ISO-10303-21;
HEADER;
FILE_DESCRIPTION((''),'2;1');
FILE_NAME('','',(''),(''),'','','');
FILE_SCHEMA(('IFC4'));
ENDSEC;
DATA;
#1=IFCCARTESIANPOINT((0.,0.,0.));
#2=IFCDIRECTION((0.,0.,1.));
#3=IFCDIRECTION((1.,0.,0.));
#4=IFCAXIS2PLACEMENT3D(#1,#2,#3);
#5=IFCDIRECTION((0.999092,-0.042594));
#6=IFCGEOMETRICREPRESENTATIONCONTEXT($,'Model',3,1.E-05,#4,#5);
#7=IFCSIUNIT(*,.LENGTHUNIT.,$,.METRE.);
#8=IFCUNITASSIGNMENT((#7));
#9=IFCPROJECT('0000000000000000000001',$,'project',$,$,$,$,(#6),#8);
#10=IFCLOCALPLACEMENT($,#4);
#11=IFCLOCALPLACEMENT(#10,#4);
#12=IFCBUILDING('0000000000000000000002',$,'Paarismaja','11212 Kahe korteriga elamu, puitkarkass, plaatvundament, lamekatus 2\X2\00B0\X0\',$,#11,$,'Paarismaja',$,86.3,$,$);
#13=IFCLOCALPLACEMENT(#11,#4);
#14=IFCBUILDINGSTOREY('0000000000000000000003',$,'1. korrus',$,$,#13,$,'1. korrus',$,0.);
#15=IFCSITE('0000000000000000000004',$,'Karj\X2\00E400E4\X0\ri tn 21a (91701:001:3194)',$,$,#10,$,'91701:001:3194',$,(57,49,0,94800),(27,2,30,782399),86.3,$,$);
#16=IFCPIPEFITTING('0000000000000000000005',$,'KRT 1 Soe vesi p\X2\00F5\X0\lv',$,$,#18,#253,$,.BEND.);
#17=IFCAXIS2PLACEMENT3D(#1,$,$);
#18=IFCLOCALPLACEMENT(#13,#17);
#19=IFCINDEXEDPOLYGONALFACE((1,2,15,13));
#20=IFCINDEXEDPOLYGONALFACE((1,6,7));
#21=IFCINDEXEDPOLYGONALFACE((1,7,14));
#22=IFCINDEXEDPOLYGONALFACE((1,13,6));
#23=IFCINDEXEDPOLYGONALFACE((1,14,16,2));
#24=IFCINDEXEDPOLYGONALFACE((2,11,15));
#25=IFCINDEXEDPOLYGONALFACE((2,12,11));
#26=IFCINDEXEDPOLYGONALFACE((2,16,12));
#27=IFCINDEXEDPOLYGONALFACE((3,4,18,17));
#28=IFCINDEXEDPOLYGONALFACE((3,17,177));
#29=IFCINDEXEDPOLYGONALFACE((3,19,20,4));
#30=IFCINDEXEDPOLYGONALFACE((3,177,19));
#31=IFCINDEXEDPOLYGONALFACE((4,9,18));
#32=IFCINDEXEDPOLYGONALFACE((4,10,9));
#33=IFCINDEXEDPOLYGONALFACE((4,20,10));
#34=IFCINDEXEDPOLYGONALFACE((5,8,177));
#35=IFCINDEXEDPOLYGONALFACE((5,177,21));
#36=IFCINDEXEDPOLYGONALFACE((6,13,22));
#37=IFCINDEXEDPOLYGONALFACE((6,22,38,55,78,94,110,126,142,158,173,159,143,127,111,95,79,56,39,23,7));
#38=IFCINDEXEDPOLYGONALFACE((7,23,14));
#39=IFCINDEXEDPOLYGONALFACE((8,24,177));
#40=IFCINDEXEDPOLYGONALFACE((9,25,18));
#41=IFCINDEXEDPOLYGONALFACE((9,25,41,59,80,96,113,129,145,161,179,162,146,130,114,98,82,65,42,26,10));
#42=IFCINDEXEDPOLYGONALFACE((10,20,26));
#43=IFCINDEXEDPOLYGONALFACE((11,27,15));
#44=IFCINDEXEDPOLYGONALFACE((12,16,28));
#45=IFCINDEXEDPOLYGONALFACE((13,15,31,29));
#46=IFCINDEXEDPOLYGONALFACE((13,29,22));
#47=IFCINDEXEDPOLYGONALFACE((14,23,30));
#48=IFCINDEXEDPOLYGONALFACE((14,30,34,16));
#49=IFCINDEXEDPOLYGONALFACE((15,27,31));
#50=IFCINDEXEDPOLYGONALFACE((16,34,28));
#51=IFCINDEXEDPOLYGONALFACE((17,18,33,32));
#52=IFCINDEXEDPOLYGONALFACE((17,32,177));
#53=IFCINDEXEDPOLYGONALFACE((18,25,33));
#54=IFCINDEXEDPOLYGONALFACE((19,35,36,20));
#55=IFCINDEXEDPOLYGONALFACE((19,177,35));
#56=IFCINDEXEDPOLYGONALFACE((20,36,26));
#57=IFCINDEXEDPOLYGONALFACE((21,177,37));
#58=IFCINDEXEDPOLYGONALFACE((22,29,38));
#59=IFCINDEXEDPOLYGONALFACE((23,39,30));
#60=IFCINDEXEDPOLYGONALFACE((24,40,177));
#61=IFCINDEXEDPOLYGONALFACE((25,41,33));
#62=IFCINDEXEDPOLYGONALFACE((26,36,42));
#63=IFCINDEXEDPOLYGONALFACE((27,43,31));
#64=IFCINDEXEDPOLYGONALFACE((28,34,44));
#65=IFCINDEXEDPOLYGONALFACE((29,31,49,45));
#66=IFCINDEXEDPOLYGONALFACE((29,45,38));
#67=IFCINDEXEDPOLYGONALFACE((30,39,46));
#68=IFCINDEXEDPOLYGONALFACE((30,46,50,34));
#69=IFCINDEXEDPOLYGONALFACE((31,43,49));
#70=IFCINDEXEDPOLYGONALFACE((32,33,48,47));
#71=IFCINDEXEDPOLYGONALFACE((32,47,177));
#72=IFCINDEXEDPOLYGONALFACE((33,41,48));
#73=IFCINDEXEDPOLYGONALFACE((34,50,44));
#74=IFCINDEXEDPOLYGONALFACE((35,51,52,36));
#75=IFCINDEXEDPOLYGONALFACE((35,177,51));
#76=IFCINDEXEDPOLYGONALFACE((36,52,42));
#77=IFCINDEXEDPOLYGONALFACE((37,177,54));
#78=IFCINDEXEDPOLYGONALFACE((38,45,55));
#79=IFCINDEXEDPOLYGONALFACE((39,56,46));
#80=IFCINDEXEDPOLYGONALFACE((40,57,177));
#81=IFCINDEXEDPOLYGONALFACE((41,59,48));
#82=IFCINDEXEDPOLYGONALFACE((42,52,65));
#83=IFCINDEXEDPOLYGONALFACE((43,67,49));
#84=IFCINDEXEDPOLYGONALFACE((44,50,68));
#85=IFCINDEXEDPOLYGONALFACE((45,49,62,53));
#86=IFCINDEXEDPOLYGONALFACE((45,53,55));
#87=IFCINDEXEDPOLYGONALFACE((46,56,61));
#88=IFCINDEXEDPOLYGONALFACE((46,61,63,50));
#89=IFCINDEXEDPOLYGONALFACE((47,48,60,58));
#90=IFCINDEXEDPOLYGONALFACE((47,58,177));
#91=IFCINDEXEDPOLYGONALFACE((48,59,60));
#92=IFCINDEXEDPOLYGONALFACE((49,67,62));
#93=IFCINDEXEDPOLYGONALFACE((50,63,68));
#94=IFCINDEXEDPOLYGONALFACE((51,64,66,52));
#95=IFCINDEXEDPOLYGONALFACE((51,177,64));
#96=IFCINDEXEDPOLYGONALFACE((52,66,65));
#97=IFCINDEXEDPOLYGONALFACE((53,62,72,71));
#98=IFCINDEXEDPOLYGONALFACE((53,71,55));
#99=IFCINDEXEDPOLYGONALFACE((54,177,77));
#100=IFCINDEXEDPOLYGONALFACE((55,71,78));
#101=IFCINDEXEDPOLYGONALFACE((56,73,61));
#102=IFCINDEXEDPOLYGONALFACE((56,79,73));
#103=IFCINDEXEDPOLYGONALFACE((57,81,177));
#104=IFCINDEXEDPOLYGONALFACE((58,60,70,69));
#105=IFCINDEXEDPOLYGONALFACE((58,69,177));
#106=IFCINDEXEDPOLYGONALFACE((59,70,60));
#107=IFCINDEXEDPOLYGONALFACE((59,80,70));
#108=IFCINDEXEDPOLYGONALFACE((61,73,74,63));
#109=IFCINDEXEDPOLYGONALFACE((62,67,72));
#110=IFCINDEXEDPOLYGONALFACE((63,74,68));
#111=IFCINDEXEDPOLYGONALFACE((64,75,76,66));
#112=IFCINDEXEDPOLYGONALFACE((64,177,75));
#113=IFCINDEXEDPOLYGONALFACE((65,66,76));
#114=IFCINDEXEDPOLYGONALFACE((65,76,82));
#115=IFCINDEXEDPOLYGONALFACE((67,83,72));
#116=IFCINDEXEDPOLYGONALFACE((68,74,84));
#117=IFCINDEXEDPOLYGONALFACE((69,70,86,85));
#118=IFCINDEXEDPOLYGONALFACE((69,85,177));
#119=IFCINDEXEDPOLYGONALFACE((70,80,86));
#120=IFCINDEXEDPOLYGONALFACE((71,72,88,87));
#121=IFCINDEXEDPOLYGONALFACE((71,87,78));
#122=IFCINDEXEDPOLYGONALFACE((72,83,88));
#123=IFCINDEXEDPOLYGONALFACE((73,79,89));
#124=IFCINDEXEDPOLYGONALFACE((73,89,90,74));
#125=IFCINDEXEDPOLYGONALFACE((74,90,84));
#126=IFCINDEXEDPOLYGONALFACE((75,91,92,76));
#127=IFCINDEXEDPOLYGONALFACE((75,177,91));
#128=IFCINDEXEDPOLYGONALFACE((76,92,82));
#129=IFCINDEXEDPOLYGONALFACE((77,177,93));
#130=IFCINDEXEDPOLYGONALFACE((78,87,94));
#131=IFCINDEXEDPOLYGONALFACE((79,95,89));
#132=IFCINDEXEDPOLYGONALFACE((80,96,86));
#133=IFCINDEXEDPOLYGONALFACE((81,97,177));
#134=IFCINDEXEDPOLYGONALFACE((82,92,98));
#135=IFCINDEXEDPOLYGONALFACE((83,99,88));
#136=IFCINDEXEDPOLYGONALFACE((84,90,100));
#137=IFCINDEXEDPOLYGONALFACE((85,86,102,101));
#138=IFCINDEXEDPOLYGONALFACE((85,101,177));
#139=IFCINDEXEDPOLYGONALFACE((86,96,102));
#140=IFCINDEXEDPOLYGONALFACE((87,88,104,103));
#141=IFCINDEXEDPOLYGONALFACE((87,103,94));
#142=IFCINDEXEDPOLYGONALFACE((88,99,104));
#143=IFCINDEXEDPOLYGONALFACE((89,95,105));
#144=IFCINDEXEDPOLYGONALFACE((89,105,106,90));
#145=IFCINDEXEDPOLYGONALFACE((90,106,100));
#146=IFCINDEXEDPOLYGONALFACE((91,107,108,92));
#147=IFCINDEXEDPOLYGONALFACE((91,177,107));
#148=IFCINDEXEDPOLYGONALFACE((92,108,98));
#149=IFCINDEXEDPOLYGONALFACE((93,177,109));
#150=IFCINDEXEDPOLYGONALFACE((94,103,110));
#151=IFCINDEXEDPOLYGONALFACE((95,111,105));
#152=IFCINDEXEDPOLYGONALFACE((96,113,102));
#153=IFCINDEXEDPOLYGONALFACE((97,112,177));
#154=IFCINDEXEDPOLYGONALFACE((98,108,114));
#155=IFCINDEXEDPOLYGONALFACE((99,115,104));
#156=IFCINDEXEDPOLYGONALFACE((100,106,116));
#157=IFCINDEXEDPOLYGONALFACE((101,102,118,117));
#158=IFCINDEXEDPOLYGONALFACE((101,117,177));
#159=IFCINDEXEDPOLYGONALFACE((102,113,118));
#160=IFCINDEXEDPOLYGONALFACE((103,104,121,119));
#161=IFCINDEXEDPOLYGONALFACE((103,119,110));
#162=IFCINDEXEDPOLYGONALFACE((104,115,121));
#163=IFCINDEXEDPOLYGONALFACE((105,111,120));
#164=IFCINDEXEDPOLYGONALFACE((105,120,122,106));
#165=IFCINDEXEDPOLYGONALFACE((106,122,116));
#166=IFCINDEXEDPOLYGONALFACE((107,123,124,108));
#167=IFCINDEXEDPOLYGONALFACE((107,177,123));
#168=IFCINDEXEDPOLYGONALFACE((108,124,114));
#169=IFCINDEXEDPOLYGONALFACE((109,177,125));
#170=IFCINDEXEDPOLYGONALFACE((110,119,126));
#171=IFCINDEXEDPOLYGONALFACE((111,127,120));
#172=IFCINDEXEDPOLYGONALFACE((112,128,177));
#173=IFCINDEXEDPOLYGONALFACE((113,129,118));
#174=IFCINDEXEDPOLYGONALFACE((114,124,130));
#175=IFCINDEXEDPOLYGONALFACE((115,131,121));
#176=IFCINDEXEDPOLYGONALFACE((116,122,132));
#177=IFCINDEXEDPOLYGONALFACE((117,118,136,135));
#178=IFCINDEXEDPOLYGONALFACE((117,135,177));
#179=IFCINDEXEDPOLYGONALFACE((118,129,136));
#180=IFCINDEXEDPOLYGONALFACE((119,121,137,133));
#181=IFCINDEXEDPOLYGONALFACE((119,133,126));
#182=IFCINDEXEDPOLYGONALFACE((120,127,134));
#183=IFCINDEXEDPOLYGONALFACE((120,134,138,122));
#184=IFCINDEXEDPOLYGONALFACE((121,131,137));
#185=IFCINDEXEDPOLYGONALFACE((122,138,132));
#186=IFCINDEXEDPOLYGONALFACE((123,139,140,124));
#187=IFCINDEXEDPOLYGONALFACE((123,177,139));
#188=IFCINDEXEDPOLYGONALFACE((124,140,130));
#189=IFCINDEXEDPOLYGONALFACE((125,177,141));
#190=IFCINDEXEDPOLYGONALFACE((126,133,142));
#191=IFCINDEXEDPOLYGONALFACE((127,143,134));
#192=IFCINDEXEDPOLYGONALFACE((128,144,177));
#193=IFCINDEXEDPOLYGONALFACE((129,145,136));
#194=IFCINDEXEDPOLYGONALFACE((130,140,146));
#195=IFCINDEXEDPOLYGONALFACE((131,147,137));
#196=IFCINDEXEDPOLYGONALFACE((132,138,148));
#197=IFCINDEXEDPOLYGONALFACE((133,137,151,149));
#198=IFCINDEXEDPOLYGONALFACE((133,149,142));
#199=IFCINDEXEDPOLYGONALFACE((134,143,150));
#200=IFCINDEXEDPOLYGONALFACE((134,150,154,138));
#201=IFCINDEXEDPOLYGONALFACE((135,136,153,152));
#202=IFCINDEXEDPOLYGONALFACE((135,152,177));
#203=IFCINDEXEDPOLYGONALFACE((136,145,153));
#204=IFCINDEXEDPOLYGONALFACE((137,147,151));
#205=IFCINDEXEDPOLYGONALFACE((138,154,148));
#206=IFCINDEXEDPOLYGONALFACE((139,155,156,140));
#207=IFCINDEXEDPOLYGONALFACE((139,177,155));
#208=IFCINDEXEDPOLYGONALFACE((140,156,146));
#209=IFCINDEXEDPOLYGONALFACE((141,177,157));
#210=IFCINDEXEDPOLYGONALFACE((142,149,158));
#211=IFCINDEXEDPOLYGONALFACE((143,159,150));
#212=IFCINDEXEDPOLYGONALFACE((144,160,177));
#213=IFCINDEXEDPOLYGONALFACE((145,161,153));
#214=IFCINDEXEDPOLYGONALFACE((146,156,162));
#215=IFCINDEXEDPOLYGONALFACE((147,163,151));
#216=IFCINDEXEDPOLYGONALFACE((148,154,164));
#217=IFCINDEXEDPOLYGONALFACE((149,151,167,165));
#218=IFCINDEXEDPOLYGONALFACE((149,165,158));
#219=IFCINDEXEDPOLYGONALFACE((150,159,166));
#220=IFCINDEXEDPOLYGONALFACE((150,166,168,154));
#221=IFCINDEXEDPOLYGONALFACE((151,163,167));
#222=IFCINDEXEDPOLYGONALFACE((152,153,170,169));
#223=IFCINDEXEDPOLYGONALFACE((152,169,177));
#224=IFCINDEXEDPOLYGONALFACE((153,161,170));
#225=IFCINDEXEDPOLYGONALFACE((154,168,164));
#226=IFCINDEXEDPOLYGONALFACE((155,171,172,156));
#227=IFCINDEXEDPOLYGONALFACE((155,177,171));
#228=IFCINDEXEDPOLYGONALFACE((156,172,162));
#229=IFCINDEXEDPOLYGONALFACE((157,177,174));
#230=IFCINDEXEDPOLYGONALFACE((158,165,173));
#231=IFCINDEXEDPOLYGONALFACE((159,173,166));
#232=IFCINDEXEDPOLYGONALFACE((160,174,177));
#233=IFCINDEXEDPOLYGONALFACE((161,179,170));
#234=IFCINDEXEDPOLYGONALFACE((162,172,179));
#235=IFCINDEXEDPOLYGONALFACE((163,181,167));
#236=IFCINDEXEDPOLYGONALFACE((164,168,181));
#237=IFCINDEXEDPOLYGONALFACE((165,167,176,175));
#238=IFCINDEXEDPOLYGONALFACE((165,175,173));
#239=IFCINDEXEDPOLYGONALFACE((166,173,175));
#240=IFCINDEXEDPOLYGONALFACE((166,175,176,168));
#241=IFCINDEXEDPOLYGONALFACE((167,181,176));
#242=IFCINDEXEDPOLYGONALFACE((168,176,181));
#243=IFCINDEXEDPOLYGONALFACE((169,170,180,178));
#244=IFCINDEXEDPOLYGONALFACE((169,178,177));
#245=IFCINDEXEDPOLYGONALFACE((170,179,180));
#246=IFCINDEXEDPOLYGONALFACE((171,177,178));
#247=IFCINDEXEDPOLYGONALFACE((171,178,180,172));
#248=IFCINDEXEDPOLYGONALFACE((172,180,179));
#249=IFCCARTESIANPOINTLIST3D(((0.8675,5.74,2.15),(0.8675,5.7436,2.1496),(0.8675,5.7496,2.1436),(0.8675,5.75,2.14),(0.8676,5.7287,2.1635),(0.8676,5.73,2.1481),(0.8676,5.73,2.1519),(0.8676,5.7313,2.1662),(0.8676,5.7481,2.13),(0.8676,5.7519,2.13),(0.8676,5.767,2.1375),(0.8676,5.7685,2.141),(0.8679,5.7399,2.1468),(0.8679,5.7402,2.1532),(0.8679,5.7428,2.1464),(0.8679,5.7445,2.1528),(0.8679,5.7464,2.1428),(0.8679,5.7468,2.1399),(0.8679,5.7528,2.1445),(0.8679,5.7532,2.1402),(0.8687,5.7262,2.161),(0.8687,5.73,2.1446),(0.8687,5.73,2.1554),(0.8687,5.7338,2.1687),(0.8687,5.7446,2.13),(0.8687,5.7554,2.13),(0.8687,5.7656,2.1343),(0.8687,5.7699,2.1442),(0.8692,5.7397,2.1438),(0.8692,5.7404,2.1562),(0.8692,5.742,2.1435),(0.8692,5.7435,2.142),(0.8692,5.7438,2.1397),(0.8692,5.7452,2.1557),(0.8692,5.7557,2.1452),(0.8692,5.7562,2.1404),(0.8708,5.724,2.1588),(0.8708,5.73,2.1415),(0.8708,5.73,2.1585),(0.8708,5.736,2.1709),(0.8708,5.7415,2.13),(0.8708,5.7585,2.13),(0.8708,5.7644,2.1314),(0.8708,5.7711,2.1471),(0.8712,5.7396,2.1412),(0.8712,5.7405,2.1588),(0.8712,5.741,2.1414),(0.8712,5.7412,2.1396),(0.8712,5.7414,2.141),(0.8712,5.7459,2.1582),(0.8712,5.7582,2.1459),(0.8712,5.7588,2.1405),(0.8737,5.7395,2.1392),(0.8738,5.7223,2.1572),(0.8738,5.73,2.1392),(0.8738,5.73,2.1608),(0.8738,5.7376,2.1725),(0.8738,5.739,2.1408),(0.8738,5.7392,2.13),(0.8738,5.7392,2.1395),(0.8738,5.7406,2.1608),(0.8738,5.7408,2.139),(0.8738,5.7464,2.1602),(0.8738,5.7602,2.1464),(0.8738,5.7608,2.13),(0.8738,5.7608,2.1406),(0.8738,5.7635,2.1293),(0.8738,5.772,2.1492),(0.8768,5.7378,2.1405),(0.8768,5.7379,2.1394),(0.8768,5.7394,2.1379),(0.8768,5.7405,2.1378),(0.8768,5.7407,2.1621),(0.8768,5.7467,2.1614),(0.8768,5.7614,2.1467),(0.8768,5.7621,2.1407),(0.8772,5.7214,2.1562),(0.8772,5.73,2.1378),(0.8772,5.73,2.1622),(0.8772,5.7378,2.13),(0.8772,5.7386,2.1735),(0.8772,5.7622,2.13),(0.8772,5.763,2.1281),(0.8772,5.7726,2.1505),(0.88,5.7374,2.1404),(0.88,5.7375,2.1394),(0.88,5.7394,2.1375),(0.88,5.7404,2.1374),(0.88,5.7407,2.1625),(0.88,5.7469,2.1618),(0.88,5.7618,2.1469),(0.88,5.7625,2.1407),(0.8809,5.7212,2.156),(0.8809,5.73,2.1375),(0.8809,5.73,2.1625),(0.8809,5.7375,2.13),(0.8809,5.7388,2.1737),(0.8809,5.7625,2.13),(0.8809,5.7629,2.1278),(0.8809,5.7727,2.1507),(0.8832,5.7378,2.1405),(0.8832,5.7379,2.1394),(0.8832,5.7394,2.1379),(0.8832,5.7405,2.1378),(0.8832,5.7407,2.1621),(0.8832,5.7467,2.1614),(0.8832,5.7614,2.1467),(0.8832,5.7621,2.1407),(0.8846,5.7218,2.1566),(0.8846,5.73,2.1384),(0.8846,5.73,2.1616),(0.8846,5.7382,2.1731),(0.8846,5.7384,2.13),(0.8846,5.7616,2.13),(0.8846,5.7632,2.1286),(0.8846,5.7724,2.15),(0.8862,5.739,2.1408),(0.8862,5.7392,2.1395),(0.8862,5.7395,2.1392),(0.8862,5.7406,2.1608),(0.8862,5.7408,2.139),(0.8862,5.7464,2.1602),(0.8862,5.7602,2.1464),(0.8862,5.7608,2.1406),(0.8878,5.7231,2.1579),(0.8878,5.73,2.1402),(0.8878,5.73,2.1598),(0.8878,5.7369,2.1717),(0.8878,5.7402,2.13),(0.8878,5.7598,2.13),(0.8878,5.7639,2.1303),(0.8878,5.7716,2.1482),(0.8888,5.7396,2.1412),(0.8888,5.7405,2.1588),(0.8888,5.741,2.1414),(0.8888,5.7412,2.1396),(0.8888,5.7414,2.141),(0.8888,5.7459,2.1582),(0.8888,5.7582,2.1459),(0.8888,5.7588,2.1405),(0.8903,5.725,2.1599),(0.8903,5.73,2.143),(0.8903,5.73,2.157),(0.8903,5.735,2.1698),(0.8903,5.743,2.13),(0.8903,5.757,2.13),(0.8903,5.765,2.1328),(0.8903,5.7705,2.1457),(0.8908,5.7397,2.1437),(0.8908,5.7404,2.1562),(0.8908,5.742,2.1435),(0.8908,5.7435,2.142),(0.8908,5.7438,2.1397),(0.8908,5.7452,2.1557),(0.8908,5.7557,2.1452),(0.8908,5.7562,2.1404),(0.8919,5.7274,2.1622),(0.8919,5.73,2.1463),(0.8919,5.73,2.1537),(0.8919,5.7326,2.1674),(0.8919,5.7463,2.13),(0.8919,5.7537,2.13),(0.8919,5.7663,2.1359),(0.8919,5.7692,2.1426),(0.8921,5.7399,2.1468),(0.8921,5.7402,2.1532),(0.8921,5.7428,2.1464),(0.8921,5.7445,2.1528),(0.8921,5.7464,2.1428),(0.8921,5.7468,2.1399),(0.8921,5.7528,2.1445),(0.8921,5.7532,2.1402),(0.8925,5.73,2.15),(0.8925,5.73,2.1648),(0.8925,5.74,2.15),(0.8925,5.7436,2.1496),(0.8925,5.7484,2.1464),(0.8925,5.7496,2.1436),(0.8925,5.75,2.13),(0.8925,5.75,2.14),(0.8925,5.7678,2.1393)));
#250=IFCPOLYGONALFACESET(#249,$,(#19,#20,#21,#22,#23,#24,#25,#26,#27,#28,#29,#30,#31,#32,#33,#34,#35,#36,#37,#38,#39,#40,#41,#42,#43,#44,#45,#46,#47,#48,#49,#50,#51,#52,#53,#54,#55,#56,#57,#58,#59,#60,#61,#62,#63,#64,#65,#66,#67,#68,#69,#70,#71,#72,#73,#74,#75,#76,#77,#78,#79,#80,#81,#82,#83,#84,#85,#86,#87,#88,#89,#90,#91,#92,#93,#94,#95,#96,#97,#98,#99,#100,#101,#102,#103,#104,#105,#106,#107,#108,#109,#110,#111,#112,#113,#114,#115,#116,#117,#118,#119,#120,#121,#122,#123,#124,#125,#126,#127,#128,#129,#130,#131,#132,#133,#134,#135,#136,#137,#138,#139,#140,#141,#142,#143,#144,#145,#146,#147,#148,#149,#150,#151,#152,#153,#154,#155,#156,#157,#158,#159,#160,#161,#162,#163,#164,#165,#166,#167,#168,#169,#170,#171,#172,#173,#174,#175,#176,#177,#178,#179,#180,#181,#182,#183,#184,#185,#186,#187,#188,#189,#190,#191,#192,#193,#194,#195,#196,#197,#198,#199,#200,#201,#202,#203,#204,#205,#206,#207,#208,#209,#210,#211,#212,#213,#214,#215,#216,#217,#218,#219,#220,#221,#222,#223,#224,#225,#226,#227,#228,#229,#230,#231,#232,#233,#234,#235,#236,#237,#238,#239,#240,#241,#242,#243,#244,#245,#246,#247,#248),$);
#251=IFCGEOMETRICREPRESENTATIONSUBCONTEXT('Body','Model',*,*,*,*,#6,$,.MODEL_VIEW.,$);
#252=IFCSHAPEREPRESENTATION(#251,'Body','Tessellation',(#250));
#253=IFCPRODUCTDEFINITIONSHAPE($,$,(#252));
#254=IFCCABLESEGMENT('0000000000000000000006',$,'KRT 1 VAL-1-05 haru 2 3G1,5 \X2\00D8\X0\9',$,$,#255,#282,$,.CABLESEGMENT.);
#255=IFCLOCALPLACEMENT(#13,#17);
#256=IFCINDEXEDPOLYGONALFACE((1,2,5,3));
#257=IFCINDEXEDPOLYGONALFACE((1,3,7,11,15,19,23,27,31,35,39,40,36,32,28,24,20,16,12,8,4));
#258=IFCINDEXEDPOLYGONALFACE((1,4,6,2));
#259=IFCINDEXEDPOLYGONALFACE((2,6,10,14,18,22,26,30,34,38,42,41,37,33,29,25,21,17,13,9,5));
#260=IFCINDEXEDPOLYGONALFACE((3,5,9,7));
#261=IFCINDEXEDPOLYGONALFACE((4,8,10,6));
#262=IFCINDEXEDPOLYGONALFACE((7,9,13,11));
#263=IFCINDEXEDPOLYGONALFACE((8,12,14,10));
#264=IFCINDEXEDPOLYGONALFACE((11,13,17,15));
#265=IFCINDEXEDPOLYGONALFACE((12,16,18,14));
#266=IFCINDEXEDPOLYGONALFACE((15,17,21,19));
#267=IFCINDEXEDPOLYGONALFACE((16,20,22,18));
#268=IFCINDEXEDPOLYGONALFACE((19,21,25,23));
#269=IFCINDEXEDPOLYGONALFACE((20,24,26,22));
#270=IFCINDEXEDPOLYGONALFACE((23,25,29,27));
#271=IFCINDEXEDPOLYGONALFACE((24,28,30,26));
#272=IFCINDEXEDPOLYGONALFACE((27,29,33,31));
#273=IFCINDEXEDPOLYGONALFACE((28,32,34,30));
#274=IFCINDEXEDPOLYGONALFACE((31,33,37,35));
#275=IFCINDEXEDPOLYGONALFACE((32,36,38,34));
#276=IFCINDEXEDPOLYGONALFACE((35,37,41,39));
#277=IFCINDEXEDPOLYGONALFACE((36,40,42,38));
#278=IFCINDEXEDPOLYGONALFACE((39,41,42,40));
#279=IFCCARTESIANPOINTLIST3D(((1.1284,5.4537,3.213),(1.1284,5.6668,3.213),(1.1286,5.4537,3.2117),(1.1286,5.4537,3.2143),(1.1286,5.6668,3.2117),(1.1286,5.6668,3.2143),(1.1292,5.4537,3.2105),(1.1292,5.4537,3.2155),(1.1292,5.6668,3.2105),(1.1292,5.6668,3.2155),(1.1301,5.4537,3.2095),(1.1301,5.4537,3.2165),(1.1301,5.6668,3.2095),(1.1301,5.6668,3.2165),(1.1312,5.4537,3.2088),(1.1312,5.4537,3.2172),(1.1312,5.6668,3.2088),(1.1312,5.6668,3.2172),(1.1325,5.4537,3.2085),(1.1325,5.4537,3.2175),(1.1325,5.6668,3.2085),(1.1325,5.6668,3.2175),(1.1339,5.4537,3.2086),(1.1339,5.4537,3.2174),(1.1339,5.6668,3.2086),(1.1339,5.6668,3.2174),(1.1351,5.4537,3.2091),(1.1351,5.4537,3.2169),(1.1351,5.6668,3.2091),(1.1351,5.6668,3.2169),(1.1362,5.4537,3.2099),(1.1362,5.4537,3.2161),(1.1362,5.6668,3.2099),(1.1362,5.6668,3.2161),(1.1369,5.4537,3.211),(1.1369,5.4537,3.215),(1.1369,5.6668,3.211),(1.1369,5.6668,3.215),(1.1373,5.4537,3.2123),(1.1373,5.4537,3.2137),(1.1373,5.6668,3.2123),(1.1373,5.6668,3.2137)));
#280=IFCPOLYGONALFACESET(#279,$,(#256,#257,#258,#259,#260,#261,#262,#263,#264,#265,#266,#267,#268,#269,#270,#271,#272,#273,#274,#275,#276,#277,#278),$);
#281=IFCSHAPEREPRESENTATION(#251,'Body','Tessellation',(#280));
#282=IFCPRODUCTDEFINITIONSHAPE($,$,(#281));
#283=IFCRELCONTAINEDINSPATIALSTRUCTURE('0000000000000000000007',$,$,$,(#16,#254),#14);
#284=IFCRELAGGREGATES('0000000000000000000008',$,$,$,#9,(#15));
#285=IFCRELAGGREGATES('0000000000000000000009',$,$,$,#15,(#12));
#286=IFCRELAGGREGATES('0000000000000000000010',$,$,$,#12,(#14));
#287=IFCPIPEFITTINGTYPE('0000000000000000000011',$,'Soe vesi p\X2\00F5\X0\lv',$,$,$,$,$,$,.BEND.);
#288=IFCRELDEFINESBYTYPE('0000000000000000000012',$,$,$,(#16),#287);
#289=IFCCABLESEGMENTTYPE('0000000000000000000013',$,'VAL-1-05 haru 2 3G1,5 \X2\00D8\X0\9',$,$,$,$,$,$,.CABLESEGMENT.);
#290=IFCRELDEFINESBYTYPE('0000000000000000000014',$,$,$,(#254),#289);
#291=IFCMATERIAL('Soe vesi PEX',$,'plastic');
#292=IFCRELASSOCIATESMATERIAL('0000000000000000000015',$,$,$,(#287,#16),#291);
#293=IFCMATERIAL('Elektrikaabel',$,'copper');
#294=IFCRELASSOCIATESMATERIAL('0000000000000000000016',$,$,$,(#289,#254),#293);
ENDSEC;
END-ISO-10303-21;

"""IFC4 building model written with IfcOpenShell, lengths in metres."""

from ifc_helpers import new_model, entity, si_unit, direction, frame, origin_with_axes, place, context, subcontext, project, spatial, circle, extrude, material, type_object, element, save


model = new_model("IFC4")

# Units and contexts
model_context = context("Model", 3, precision=1e-05, world=origin_with_axes(), true_north=direction((0.999092, -0.042594)))
body_context = subcontext(model_context, "Body", "Model", "MODEL_VIEW")
ifc_project = project(units=[si_unit("LENGTHUNIT", "METRE")], contexts=[model_context])

# Site, building, storey
site_placement = place(None, origin_with_axes())
site = spatial("IfcSite", under=ifc_project, at=site_placement, Name="Karjääri tn 21a (91701:001:3194)", LongName="91701:001:3194", RefLatitude=(57, 49, 0, 94800), RefLongitude=(27, 2, 30, 782399), RefElevation=86.3)
building_placement = place(site_placement, origin_with_axes())
building = spatial("IfcBuilding", under=site, at=building_placement, Name="Paarismaja", Description="11212 Kahe korteriga elamu, puitkarkass, plaatvundament, lamekatus 2°", LongName="Paarismaja", ElevationOfRefHeight=86.3)
storey_placement = place(building_placement, origin_with_axes())
storey = spatial("IfcBuildingStorey", under=building, at=storey_placement, Name="1. korrus", LongName="1. korrus", Elevation=0.0)

# Shared definitions
ifc_material_1 = material(Name="Elektrikaabel", Category="copper")

# Pipe fitting
ifc_material_2 = material(Name="Soe vesi PEX", Category="plastic")
pipe_fitting_type_1 = type_object("IfcPipeFittingType", Name="Soe vesi põlv", PredefinedType="BEND", material=ifc_material_2)
pipe_fitting_1_placement = place(storey_placement, frame((0.88, 5.75, 2.15), z_axis=(0.0, 0.0, 1.0), x_axis=(1.0, 0.0, 0.0)))
element("IfcPipeFitting", 1, at=pipe_fitting_1_placement, inside=storey, type_object=pipe_fitting_type_1, material=ifc_material_2, Name="KRT 1 Soe vesi põlv", PredefinedType="BEND", context=body_context, shape_type="AdvancedSweptSolid", body=[
    entity("IfcSweptDiskSolid", entity("IfcIndexedPolyCurve", entity("IfcCartesianPointList3D", [[0.0, 0.0, -0.02], [0.0, 0.0, -0.01], [0.0, -0.0004, -0.0064], [0.0, -0.0016, -0.0036], [0.0, -0.0036, -0.0016], [0.0, -0.0064, -0.0004], [0.0, -0.01, 0.0], [0.0, -0.02, 0.0]]), None, False), 0.0125),
])

# Cable segment
cable_segment_type_1 = type_object("IfcCableSegmentType", Name="VAL-1-05 haru 2 3G1,5 Ø9", PredefinedType="CABLESEGMENT", material=ifc_material_1)
cable_segment_1_placement = place(storey_placement, frame((1.1329, 5.6668, 3.213), z_axis=(0.0, -1.0, 0.0), x_axis=(-1.0, 0.0, 0.0)))
element("IfcCableSegment", 2, at=cable_segment_1_placement, inside=storey, type_object=cable_segment_type_1, material=ifc_material_1, Name="KRT 1 VAL-1-05 haru 2 3G1,5 Ø9", PredefinedType="CABLESEGMENT", context=body_context, shape_type="SweptSolid", body=[
    extrude(circle(Radius=0.0045), origin_with_axes(), (0.0, 0.0, 1.0), 0.2131),
])

save(model, "model.ifc")
